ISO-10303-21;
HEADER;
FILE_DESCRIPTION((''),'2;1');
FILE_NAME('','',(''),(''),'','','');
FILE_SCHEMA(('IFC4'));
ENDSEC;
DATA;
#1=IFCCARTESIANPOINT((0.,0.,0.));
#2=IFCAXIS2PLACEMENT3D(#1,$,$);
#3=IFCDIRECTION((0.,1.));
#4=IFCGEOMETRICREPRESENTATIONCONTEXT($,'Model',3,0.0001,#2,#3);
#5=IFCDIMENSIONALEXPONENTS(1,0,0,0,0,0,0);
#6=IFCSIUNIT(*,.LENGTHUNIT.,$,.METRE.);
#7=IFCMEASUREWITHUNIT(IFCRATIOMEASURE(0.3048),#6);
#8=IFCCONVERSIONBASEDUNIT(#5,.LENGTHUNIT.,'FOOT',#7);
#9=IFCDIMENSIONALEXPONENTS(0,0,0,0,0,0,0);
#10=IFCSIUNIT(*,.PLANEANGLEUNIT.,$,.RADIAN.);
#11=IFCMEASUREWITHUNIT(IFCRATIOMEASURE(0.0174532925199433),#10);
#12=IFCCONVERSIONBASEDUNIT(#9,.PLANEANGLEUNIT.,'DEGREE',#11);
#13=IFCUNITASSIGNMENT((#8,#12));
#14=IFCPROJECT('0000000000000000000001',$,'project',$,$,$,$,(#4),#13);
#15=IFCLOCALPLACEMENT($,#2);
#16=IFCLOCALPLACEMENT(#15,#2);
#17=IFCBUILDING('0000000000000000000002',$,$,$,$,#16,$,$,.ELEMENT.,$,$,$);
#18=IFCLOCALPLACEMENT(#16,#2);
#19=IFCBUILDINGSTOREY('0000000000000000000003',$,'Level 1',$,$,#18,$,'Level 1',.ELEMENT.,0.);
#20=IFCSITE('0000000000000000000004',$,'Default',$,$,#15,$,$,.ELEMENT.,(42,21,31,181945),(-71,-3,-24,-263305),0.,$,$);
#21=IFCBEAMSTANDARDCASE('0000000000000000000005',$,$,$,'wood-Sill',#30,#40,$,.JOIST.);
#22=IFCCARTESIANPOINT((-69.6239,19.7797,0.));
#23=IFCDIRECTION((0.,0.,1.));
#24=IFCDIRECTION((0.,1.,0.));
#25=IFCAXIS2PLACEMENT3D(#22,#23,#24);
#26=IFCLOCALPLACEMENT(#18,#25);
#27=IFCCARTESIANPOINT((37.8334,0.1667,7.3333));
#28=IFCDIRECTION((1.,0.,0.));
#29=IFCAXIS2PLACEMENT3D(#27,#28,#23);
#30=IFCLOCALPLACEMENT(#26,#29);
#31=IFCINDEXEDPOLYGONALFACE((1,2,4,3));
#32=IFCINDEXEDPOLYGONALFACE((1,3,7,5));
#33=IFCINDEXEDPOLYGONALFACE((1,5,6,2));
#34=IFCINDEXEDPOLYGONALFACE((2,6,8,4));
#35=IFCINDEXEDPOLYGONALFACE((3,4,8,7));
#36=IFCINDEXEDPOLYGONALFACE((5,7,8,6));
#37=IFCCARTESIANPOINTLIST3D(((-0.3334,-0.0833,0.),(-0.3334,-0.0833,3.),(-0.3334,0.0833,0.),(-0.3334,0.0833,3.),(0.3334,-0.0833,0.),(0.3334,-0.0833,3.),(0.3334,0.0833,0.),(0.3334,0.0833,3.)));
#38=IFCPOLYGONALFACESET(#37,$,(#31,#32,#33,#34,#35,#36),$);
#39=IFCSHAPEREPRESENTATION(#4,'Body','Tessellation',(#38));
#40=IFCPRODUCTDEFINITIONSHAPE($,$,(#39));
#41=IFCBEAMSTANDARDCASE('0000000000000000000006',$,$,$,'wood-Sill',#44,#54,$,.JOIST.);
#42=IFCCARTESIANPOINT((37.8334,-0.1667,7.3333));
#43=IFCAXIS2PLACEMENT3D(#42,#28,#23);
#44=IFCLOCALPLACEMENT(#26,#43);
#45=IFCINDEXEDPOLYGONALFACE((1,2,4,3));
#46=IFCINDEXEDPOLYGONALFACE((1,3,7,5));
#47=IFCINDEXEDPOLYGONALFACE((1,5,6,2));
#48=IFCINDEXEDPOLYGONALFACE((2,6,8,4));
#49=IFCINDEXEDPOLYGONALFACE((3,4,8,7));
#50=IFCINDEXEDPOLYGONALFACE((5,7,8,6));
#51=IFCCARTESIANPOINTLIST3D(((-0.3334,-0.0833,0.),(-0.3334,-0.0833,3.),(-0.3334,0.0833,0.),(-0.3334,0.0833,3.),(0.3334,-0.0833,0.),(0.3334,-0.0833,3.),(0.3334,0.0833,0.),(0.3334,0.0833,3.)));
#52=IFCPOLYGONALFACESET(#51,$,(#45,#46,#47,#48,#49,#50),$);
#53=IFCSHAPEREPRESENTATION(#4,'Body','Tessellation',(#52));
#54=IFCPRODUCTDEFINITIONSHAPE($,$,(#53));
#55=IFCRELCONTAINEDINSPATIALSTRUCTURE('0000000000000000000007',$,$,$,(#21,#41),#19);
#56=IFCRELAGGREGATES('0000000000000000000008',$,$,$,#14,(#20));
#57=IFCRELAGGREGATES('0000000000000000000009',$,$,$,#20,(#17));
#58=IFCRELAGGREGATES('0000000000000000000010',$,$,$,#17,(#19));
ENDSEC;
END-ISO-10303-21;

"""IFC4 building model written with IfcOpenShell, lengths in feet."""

from ifc_helpers import new_model, entity, si_unit, converted_unit, direction, frame, origin, origin_with_axes, place, context, project, spatial, rectangle, extrude, element, save


model = new_model("IFC4")

# Units and contexts
model_context = context("Model", 3, precision=0.0001, world=origin(), true_north=direction((0.0, 1.0)))
ifc_project = project(units=[converted_unit("LENGTHUNIT", "FOOT", entity("IfcRatioMeasure", 0.3048), si_unit("LENGTHUNIT", "METRE"), dimensions=[1, 0, 0, 0, 0, 0, 0]), converted_unit("PLANEANGLEUNIT", "DEGREE", entity("IfcRatioMeasure", 0.0174532925199433), si_unit("PLANEANGLEUNIT", "RADIAN"), dimensions=[0, 0, 0, 0, 0, 0, 0])], contexts=[model_context])

# Site, building, storey
site_placement = place(None, origin())
site = spatial("IfcSite", under=ifc_project, at=site_placement, Name="Default", CompositionType="ELEMENT", RefLatitude=(42, 21, 31, 181945), RefLongitude=(-71, -3, -24, -263305), RefElevation=0.0)
building_placement = place(site_placement, origin())
building = spatial("IfcBuilding", under=site, at=building_placement, CompositionType="ELEMENT")
storey_placement = place(building_placement, origin())
storey = spatial("IfcBuildingStorey", under=building, at=storey_placement, Name="Level 1", LongName="Level 1", CompositionType="ELEMENT", Elevation=0.0)

# Shared definitions
placement_1 = place(storey_placement, frame((-69.6239, 19.7797, 0.0), z_axis=(0.0, 0.0, 1.0), x_axis=(0.0, 1.0, 0.0)))

# Beams
for number, where, z_axis, x_axis in (
    (1, (37.8334, 0.1667, 7.3333), (1.0, 0.0, 0.0), (0.0, 0.0, 1.0)),
    (2, (37.8334, -0.1667, 7.3333), (1.0, 0.0, 0.0), (0.0, 0.0, 1.0)),
):
    element("IfcBeamStandardCase", number, at=place(placement_1, frame(where, z_axis=z_axis, x_axis=x_axis)), inside=storey, ObjectType="wood-Sill", PredefinedType="JOIST", context=model_context, shape_type="SweptSolid", body=[
        extrude(rectangle(XDim=0.6667, YDim=0.1667), origin_with_axes(), (0.0, 0.0, 1.0), 3.0),
    ])

save(model, "model.ifc")
